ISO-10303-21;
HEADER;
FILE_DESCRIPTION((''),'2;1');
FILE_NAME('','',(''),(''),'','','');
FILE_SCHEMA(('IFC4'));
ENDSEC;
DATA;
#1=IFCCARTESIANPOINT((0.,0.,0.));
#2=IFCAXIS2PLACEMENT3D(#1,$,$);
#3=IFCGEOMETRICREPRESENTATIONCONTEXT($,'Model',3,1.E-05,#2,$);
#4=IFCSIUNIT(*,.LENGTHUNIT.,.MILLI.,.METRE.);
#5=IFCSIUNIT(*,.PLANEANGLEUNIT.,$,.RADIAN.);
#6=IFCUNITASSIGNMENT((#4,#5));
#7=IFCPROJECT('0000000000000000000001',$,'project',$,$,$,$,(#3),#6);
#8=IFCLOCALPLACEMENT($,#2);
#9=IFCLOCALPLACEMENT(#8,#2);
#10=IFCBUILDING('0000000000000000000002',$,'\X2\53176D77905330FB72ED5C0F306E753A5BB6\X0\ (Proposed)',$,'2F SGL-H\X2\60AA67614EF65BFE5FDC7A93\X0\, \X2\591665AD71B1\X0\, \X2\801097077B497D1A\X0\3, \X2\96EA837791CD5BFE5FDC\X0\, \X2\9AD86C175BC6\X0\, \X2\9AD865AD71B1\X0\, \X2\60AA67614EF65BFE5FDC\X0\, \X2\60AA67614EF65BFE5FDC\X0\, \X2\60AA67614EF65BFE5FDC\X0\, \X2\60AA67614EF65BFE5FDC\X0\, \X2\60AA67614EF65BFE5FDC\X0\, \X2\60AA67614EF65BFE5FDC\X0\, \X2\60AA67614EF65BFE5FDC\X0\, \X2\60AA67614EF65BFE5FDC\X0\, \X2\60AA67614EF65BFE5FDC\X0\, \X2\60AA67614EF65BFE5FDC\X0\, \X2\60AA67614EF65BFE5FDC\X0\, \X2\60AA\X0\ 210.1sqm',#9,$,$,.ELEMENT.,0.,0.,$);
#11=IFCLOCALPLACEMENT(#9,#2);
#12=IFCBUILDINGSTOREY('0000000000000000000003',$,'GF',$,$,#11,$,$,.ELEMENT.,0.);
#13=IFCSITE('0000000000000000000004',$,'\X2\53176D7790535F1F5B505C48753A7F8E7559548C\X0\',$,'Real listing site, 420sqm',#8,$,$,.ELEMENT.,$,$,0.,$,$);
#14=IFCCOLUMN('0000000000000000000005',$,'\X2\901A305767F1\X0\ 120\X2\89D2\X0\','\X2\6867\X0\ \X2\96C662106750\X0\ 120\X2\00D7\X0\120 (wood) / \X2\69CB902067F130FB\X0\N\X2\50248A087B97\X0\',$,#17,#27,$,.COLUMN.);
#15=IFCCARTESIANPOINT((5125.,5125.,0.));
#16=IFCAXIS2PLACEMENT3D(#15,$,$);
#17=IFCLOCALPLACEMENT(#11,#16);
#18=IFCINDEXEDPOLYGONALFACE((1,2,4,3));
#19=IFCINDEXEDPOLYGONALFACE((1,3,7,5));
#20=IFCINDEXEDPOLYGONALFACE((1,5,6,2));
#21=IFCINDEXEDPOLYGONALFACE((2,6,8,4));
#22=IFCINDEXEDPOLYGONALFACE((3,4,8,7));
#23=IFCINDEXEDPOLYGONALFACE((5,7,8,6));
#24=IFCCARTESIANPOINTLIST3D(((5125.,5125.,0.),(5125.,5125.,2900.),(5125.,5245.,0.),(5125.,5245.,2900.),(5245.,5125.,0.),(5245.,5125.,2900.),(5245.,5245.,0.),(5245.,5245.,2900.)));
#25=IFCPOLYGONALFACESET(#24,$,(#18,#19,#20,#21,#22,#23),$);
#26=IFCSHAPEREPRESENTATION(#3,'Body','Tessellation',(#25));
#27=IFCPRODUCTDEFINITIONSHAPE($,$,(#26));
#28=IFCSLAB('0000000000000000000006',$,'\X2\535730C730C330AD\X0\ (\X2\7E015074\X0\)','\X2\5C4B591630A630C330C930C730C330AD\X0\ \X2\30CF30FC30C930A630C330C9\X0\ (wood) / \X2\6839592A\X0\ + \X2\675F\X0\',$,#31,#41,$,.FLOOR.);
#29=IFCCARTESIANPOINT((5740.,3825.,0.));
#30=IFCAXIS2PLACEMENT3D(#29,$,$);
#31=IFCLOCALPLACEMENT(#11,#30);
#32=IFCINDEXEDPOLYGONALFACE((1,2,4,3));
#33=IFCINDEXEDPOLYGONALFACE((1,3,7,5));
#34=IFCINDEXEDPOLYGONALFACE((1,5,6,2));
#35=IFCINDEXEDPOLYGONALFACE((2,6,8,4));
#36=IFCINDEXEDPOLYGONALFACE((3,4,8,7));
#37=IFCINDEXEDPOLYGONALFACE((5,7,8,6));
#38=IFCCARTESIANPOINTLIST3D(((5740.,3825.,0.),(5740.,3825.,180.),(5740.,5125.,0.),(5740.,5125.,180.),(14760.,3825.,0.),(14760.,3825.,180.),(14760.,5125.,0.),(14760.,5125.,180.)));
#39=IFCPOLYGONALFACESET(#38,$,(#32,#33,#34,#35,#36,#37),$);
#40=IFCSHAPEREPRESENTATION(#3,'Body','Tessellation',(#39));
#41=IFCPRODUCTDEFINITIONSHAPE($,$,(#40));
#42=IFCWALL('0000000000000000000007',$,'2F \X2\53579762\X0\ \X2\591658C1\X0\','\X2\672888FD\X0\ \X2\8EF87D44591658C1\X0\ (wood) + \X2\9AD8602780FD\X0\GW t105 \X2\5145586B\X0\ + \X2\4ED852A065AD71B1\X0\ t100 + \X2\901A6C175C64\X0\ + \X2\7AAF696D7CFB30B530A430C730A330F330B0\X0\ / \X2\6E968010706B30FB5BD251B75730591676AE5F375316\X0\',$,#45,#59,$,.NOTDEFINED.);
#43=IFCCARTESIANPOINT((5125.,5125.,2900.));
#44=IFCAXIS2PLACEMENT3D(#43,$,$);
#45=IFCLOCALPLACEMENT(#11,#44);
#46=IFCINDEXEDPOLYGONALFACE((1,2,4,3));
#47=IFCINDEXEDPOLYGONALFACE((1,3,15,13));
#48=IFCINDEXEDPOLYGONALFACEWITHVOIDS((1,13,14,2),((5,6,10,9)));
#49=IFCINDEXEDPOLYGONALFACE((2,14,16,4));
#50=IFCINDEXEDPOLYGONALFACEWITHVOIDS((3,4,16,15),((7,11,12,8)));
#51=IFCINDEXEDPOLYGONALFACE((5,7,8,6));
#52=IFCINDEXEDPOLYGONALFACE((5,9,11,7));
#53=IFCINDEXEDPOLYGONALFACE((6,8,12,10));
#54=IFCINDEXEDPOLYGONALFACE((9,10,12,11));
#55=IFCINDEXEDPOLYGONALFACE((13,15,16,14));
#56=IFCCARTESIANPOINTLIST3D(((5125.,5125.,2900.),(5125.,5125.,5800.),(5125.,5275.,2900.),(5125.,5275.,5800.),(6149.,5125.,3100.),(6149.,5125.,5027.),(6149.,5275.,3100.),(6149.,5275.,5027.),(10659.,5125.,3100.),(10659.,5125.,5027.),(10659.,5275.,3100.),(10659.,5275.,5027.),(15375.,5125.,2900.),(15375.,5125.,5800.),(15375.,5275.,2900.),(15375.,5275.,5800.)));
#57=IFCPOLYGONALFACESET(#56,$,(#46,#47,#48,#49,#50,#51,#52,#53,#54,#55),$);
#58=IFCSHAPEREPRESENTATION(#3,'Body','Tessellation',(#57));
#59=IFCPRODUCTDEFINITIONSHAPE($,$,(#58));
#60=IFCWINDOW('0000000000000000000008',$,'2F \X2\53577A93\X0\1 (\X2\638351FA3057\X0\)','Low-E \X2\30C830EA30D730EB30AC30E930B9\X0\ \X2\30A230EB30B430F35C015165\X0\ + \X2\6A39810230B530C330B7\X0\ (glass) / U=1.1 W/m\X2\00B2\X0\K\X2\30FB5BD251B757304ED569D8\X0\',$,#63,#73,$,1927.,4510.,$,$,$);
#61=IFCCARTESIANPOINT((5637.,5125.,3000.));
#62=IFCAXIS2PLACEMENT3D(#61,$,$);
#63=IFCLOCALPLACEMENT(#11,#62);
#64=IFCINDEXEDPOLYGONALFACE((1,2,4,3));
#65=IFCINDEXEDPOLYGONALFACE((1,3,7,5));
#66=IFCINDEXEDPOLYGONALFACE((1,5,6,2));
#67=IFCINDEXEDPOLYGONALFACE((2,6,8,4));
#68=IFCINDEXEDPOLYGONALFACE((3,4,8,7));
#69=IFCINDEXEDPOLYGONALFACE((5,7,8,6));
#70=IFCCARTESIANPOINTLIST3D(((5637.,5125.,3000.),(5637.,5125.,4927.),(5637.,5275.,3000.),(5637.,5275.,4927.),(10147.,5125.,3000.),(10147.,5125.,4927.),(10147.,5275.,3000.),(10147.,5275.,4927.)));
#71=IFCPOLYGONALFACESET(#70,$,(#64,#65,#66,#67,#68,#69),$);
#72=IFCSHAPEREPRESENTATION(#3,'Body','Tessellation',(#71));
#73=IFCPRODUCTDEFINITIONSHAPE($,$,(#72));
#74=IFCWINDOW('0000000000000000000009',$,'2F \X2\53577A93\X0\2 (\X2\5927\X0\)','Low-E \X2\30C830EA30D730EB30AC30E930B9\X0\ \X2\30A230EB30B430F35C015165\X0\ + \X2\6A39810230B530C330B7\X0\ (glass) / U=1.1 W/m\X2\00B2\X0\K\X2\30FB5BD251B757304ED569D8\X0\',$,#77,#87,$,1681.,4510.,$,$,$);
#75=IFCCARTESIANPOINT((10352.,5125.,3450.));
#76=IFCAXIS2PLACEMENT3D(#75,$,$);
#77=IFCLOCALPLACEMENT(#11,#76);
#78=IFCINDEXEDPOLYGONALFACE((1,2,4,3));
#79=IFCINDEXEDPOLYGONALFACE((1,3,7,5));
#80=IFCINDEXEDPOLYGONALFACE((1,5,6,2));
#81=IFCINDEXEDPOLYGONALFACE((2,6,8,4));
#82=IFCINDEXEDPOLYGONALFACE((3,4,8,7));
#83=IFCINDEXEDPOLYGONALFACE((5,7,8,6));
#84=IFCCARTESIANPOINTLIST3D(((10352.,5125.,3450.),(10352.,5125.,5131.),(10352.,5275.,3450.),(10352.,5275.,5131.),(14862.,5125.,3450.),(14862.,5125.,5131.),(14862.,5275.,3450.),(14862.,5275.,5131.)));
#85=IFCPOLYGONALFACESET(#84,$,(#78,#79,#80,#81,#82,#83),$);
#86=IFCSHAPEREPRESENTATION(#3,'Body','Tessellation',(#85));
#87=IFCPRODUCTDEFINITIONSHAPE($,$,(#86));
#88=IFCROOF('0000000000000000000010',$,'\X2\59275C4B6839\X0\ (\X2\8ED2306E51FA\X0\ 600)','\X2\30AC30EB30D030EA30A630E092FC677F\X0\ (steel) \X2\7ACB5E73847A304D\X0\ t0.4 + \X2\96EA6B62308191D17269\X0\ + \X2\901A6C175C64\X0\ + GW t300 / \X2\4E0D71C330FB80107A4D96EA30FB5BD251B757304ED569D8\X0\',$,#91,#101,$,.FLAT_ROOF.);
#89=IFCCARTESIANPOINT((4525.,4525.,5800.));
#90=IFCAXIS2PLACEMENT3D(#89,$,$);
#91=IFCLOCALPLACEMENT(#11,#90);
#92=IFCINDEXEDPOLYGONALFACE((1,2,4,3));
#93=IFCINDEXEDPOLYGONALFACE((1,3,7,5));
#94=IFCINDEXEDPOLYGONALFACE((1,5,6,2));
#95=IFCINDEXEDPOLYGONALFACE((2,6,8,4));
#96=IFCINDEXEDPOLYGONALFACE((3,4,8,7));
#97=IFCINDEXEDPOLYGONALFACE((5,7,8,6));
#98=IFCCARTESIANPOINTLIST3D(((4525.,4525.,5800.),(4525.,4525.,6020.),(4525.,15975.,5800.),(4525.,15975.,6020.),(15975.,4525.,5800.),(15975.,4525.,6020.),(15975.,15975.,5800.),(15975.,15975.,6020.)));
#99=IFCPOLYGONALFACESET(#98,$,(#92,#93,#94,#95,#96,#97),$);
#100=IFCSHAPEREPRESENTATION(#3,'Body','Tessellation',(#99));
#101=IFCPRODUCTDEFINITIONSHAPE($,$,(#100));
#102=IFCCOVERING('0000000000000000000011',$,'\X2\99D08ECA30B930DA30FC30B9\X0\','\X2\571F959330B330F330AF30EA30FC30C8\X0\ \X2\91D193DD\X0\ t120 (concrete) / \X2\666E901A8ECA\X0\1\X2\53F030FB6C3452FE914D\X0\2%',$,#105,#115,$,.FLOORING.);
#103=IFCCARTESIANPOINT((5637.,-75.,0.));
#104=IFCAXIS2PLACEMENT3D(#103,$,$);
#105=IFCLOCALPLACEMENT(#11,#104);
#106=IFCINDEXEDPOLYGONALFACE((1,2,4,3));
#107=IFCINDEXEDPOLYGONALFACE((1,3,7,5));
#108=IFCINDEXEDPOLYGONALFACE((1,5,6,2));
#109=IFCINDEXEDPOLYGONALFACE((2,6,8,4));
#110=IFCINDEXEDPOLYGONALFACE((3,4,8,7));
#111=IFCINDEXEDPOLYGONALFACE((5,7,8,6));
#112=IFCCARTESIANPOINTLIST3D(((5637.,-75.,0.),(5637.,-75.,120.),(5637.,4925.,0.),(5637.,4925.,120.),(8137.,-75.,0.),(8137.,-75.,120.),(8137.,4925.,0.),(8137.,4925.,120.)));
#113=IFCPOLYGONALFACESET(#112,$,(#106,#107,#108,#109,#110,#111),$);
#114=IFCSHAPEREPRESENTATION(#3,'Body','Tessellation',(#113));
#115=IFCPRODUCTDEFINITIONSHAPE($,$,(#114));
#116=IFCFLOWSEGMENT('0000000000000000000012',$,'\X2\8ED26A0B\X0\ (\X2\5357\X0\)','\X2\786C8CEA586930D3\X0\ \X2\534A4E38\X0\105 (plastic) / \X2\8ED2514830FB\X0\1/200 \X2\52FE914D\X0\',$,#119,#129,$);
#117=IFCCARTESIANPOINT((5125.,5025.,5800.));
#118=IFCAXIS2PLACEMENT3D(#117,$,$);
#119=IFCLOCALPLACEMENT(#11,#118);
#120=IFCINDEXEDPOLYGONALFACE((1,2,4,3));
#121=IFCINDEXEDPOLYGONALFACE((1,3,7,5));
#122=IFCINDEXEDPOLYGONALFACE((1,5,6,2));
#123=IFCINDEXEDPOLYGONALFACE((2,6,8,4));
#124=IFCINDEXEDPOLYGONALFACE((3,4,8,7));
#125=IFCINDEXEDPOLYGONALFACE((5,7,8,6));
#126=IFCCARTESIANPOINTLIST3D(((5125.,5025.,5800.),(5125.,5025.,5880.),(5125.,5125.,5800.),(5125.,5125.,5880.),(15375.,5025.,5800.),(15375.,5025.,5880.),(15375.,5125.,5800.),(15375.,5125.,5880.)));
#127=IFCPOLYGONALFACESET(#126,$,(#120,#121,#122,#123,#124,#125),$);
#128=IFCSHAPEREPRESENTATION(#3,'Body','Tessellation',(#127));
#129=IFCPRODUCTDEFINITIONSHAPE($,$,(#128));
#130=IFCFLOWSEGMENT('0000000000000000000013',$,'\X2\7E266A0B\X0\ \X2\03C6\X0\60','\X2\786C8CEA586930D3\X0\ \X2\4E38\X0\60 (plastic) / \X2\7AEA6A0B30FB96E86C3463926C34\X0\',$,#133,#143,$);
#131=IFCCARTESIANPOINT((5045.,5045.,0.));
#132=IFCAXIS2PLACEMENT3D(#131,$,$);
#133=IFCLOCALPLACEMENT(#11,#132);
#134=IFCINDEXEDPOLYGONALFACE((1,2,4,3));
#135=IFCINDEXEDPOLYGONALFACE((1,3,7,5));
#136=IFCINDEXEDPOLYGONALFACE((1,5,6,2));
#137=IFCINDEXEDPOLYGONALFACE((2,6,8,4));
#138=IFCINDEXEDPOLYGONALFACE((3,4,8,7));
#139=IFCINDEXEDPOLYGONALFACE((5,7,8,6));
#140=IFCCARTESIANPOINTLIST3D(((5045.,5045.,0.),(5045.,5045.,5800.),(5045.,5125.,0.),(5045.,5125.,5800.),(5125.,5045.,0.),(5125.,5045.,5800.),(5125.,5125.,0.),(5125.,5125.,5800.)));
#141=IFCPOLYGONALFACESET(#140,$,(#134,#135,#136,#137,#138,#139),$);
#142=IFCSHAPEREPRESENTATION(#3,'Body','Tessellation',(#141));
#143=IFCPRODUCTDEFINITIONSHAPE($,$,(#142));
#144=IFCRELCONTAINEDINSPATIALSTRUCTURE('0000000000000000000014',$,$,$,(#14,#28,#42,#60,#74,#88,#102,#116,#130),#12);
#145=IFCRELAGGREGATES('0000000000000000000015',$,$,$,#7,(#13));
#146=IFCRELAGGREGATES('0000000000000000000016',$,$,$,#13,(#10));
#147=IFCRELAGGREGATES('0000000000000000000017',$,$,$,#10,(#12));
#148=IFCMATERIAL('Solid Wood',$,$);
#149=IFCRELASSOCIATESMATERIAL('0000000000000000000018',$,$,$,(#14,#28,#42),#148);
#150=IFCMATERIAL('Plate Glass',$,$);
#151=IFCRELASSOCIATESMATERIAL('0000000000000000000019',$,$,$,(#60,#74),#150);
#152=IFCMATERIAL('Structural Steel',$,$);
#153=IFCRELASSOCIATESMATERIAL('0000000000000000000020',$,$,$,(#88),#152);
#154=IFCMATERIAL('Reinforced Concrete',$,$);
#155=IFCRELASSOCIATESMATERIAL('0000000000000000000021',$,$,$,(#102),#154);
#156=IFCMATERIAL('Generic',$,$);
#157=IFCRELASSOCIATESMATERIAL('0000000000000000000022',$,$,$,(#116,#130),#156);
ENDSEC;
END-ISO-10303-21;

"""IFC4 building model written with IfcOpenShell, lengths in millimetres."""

from ifc_helpers import new_model, si_unit, frame, frame_2d, origin, place, context, project, spatial, rectangle, extrude, material, element, fill, save


model = new_model("IFC4")

# Units and contexts
model_context = context("Model", 3, precision=1e-05, world=origin())
ifc_project = project(units=[si_unit("LENGTHUNIT", "METRE", prefix="MILLI"), si_unit("PLANEANGLEUNIT", "RADIAN")], contexts=[model_context])

# Site, building, storey
site_placement = place(None, origin())
site = spatial("IfcSite", under=ifc_project, at=site_placement, Name="北海道弟子屈町美留和", ObjectType="Real listing site, 420sqm", CompositionType="ELEMENT", RefElevation=0.0)
building_placement = place(site_placement, origin())
building = spatial("IfcBuilding", under=site, at=building_placement, Name="北海道・狭小の町家 (Proposed)", ObjectType="2F SGL-H悪条件対応窓, 外断熱, 耐震等級3, 雪荷重対応, 高気密, 高断熱, 悪条件対応, 悪条件対応, 悪条件対応, 悪条件対応, 悪条件対応, 悪条件対応, 悪条件対応, 悪条件対応, 悪条件対応, 悪条件対応, 悪条件対応, 悪 210.1sqm", CompositionType="ELEMENT", ElevationOfRefHeight=0.0, ElevationOfTerrain=0.0)
storey_placement = place(building_placement, origin())
storey = spatial("IfcBuildingStorey", under=building, at=storey_placement, Name="GF", CompositionType="ELEMENT", Elevation=0.0)

# Column
ifc_material_1 = material(Name="Solid Wood")
column_placement = place(storey_placement, frame((5125.0, 5125.0, 0.0)))
element("IfcColumn", 1, at=column_placement, inside=storey, material=ifc_material_1, Name="通し柱 120角", Description="桧 集成材 120×120 (wood) / 構造柱・N値計算", PredefinedType="COLUMN", context=model_context, shape_type="SweptSolid", body=[
    extrude(rectangle(XDim=120.0, YDim=120.0, at=frame_2d((60.0, 60.0))), frame((5125.0, 5125.0, 0.0)), (0.0, 0.0, 1.0), 2900.0),
])

# Slab
ifc_material_2 = material(Name="Reinforced Concrete")
slab_1_placement = place(storey_placement, frame((5740.0, 3825.0, 0.0)))
element("IfcSlab", 2, at=slab_1_placement, inside=storey, material=ifc_material_1, Name="南デッキ (縁側)", Description="屋外ウッドデッキ ハードウッド (wood) / 根太 + 束", PredefinedType="FLOOR", context=model_context, shape_type="SweptSolid", body=[
    extrude(rectangle(XDim=9020.0, YDim=1300.0, at=frame_2d((4510.0, 650.0))), frame((5740.0, 3825.0, 0.0)), (0.0, 0.0, 1.0), 180.0),
])

# Shared definitions
ifc_material_3 = material(Name="Plate Glass")

# Wall, openings, windows
wall_1_placement = place(storey_placement, frame((5125.0, 5125.0, 2900.0)))
wall_1 = element("IfcWall", 3, at=wall_1_placement, inside=storey, material=ifc_material_1, Name="2F 南面 外壁", Description="木製 軸組外壁 (wood) + 高性能GW t105 充填 + 付加断熱 t100 + 通気層 + 窯業系サイディング / 準耐火・寒冷地外皮強化", PredefinedType="NOTDEFINED", context=model_context, shape_type="SweptSolid", body=[
    extrude(rectangle(XDim=10250.0, YDim=150.0, at=frame_2d((5125.0, 75.0))), frame((5125.0, 5125.0, 2900.0)), (0.0, 0.0, 1.0), 2900.0),
])
opening_1_placement = place(storey_placement, frame((5637.0, 5125.0, 3000.0)))
opening_1 = element("IfcOpeningElement", 4, at=opening_1_placement, cuts=wall_1, PredefinedType="NOTDEFINED", context=model_context, shape_type="SweptSolid", body=[
    extrude(rectangle(XDim=4510.0, YDim=150.0, at=frame_2d((2255.0, 75.0))), frame((5637.0, 5125.0, 3000.0)), (0.0, 0.0, 1.0), 1927.0),
])
opening_2_placement = place(storey_placement, frame((10352.0, 5125.0, 3450.0)))
opening_2 = element("IfcOpeningElement", 5, at=opening_2_placement, cuts=wall_1, PredefinedType="NOTDEFINED", context=model_context, shape_type="SweptSolid", body=[
    extrude(rectangle(XDim=4510.0, YDim=150.0, at=frame_2d((2255.0, 75.0))), frame((10352.0, 5125.0, 3450.0)), (0.0, 0.0, 1.0), 1681.0),
])
window_1_placement = place(storey_placement, frame((5637.0, 5125.0, 3000.0)))
window_1 = element("IfcWindow", 6, at=window_1_placement, inside=storey, material=ifc_material_3, Name="2F 南窓1 (掃出し)", Description="Low-E トリプルガラス アルゴン封入 + 樹脂サッシ (glass) / U=1.1 W/m²K・寒冷地仕様", OverallHeight=1927.0, OverallWidth=4510.0, context=model_context, shape_type="SweptSolid", body=[
    extrude(rectangle(XDim=4510.0, YDim=150.0, at=frame_2d((2255.0, 75.0))), frame((5637.0, 5125.0, 3000.0)), (0.0, 0.0, 1.0), 1927.0),
])
fill(opening_1, window_1)
window_2_placement = place(storey_placement, frame((10352.0, 5125.0, 3450.0)))
window_2 = element("IfcWindow", 7, at=window_2_placement, inside=storey, material=ifc_material_3, Name="2F 南窓2 (大)", Description="Low-E トリプルガラス アルゴン封入 + 樹脂サッシ (glass) / U=1.1 W/m²K・寒冷地仕様", OverallHeight=1681.0, OverallWidth=4510.0, context=model_context, shape_type="SweptSolid", body=[
    extrude(rectangle(XDim=4510.0, YDim=150.0, at=frame_2d((2255.0, 75.0))), frame((10352.0, 5125.0, 3450.0)), (0.0, 0.0, 1.0), 1681.0),
])
fill(opening_2, window_2)

# Roof
ifc_material_4 = material(Name="Structural Steel")
roof_placement = place(storey_placement, frame((4525.0, 4525.0, 5800.0)))
element("IfcRoof", 8, at=roof_placement, inside=storey, material=ifc_material_4, Name="大屋根 (軒の出 600)", Description="ガルバリウム鋼板 (steel) 立平葺き t0.4 + 雪止め金物 + 通気層 + GW t300 / 不燃・耐積雪・寒冷地仕様", PredefinedType="FLAT_ROOF", context=model_context, shape_type="SweptSolid", body=[
    extrude(rectangle(XDim=11450.0, YDim=11450.0, at=frame_2d((5725.0, 5725.0))), frame((4525.0, 4525.0, 5800.0)), (0.0, 0.0, 1.0), 220.0),
])

# Covering
covering_placement = place(storey_placement, frame((5637.0, -75.0, 0.0)))
element("IfcCovering", 9, at=covering_placement, inside=storey, material=ifc_material_2, Name="駐車スペース", Description="土間コンクリート 金鏝 t120 (concrete) / 普通車1台・水勾配2%", PredefinedType="FLOORING", context=model_context, shape_type="SweptSolid", body=[
    extrude(rectangle(XDim=2500.0, YDim=5000.0, at=frame_2d((1250.0, 2500.0))), frame((5637.0, -75.0, 0.0)), (0.0, 0.0, 1.0), 120.0),
])

# Flow segments
ifc_material_5 = material(Name="Generic")
flow_segment_1_placement = place(storey_placement, frame((5125.0, 5025.0, 5800.0)))
element("IfcFlowSegment", 10, at=flow_segment_1_placement, inside=storey, material=ifc_material_5, Name="軒樋 (南)", Description="硬質塩ビ 半丸105 (plastic) / 軒先・1/200 勾配", context=model_context, shape_type="SweptSolid", body=[
    extrude(rectangle(XDim=10250.0, YDim=100.0, at=frame_2d((5125.0, 50.0))), frame((5125.0, 5025.0, 5800.0)), (0.0, 0.0, 1.0), 80.0),
])
flow_segment_2_placement = place(storey_placement, frame((5045.0, 5045.0, 0.0)))
element("IfcFlowSegment", 11, at=flow_segment_2_placement, inside=storey, material=ifc_material_5, Name="縦樋 φ60", Description="硬質塩ビ 丸60 (plastic) / 竪樋・雨水排水", context=model_context, shape_type="SweptSolid", body=[
    extrude(rectangle(XDim=80.0, YDim=80.0, at=frame_2d((40.0, 40.0))), frame((5045.0, 5045.0, 0.0)), (0.0, 0.0, 1.0), 5800.0),
])

save(model, "model.ifc")
